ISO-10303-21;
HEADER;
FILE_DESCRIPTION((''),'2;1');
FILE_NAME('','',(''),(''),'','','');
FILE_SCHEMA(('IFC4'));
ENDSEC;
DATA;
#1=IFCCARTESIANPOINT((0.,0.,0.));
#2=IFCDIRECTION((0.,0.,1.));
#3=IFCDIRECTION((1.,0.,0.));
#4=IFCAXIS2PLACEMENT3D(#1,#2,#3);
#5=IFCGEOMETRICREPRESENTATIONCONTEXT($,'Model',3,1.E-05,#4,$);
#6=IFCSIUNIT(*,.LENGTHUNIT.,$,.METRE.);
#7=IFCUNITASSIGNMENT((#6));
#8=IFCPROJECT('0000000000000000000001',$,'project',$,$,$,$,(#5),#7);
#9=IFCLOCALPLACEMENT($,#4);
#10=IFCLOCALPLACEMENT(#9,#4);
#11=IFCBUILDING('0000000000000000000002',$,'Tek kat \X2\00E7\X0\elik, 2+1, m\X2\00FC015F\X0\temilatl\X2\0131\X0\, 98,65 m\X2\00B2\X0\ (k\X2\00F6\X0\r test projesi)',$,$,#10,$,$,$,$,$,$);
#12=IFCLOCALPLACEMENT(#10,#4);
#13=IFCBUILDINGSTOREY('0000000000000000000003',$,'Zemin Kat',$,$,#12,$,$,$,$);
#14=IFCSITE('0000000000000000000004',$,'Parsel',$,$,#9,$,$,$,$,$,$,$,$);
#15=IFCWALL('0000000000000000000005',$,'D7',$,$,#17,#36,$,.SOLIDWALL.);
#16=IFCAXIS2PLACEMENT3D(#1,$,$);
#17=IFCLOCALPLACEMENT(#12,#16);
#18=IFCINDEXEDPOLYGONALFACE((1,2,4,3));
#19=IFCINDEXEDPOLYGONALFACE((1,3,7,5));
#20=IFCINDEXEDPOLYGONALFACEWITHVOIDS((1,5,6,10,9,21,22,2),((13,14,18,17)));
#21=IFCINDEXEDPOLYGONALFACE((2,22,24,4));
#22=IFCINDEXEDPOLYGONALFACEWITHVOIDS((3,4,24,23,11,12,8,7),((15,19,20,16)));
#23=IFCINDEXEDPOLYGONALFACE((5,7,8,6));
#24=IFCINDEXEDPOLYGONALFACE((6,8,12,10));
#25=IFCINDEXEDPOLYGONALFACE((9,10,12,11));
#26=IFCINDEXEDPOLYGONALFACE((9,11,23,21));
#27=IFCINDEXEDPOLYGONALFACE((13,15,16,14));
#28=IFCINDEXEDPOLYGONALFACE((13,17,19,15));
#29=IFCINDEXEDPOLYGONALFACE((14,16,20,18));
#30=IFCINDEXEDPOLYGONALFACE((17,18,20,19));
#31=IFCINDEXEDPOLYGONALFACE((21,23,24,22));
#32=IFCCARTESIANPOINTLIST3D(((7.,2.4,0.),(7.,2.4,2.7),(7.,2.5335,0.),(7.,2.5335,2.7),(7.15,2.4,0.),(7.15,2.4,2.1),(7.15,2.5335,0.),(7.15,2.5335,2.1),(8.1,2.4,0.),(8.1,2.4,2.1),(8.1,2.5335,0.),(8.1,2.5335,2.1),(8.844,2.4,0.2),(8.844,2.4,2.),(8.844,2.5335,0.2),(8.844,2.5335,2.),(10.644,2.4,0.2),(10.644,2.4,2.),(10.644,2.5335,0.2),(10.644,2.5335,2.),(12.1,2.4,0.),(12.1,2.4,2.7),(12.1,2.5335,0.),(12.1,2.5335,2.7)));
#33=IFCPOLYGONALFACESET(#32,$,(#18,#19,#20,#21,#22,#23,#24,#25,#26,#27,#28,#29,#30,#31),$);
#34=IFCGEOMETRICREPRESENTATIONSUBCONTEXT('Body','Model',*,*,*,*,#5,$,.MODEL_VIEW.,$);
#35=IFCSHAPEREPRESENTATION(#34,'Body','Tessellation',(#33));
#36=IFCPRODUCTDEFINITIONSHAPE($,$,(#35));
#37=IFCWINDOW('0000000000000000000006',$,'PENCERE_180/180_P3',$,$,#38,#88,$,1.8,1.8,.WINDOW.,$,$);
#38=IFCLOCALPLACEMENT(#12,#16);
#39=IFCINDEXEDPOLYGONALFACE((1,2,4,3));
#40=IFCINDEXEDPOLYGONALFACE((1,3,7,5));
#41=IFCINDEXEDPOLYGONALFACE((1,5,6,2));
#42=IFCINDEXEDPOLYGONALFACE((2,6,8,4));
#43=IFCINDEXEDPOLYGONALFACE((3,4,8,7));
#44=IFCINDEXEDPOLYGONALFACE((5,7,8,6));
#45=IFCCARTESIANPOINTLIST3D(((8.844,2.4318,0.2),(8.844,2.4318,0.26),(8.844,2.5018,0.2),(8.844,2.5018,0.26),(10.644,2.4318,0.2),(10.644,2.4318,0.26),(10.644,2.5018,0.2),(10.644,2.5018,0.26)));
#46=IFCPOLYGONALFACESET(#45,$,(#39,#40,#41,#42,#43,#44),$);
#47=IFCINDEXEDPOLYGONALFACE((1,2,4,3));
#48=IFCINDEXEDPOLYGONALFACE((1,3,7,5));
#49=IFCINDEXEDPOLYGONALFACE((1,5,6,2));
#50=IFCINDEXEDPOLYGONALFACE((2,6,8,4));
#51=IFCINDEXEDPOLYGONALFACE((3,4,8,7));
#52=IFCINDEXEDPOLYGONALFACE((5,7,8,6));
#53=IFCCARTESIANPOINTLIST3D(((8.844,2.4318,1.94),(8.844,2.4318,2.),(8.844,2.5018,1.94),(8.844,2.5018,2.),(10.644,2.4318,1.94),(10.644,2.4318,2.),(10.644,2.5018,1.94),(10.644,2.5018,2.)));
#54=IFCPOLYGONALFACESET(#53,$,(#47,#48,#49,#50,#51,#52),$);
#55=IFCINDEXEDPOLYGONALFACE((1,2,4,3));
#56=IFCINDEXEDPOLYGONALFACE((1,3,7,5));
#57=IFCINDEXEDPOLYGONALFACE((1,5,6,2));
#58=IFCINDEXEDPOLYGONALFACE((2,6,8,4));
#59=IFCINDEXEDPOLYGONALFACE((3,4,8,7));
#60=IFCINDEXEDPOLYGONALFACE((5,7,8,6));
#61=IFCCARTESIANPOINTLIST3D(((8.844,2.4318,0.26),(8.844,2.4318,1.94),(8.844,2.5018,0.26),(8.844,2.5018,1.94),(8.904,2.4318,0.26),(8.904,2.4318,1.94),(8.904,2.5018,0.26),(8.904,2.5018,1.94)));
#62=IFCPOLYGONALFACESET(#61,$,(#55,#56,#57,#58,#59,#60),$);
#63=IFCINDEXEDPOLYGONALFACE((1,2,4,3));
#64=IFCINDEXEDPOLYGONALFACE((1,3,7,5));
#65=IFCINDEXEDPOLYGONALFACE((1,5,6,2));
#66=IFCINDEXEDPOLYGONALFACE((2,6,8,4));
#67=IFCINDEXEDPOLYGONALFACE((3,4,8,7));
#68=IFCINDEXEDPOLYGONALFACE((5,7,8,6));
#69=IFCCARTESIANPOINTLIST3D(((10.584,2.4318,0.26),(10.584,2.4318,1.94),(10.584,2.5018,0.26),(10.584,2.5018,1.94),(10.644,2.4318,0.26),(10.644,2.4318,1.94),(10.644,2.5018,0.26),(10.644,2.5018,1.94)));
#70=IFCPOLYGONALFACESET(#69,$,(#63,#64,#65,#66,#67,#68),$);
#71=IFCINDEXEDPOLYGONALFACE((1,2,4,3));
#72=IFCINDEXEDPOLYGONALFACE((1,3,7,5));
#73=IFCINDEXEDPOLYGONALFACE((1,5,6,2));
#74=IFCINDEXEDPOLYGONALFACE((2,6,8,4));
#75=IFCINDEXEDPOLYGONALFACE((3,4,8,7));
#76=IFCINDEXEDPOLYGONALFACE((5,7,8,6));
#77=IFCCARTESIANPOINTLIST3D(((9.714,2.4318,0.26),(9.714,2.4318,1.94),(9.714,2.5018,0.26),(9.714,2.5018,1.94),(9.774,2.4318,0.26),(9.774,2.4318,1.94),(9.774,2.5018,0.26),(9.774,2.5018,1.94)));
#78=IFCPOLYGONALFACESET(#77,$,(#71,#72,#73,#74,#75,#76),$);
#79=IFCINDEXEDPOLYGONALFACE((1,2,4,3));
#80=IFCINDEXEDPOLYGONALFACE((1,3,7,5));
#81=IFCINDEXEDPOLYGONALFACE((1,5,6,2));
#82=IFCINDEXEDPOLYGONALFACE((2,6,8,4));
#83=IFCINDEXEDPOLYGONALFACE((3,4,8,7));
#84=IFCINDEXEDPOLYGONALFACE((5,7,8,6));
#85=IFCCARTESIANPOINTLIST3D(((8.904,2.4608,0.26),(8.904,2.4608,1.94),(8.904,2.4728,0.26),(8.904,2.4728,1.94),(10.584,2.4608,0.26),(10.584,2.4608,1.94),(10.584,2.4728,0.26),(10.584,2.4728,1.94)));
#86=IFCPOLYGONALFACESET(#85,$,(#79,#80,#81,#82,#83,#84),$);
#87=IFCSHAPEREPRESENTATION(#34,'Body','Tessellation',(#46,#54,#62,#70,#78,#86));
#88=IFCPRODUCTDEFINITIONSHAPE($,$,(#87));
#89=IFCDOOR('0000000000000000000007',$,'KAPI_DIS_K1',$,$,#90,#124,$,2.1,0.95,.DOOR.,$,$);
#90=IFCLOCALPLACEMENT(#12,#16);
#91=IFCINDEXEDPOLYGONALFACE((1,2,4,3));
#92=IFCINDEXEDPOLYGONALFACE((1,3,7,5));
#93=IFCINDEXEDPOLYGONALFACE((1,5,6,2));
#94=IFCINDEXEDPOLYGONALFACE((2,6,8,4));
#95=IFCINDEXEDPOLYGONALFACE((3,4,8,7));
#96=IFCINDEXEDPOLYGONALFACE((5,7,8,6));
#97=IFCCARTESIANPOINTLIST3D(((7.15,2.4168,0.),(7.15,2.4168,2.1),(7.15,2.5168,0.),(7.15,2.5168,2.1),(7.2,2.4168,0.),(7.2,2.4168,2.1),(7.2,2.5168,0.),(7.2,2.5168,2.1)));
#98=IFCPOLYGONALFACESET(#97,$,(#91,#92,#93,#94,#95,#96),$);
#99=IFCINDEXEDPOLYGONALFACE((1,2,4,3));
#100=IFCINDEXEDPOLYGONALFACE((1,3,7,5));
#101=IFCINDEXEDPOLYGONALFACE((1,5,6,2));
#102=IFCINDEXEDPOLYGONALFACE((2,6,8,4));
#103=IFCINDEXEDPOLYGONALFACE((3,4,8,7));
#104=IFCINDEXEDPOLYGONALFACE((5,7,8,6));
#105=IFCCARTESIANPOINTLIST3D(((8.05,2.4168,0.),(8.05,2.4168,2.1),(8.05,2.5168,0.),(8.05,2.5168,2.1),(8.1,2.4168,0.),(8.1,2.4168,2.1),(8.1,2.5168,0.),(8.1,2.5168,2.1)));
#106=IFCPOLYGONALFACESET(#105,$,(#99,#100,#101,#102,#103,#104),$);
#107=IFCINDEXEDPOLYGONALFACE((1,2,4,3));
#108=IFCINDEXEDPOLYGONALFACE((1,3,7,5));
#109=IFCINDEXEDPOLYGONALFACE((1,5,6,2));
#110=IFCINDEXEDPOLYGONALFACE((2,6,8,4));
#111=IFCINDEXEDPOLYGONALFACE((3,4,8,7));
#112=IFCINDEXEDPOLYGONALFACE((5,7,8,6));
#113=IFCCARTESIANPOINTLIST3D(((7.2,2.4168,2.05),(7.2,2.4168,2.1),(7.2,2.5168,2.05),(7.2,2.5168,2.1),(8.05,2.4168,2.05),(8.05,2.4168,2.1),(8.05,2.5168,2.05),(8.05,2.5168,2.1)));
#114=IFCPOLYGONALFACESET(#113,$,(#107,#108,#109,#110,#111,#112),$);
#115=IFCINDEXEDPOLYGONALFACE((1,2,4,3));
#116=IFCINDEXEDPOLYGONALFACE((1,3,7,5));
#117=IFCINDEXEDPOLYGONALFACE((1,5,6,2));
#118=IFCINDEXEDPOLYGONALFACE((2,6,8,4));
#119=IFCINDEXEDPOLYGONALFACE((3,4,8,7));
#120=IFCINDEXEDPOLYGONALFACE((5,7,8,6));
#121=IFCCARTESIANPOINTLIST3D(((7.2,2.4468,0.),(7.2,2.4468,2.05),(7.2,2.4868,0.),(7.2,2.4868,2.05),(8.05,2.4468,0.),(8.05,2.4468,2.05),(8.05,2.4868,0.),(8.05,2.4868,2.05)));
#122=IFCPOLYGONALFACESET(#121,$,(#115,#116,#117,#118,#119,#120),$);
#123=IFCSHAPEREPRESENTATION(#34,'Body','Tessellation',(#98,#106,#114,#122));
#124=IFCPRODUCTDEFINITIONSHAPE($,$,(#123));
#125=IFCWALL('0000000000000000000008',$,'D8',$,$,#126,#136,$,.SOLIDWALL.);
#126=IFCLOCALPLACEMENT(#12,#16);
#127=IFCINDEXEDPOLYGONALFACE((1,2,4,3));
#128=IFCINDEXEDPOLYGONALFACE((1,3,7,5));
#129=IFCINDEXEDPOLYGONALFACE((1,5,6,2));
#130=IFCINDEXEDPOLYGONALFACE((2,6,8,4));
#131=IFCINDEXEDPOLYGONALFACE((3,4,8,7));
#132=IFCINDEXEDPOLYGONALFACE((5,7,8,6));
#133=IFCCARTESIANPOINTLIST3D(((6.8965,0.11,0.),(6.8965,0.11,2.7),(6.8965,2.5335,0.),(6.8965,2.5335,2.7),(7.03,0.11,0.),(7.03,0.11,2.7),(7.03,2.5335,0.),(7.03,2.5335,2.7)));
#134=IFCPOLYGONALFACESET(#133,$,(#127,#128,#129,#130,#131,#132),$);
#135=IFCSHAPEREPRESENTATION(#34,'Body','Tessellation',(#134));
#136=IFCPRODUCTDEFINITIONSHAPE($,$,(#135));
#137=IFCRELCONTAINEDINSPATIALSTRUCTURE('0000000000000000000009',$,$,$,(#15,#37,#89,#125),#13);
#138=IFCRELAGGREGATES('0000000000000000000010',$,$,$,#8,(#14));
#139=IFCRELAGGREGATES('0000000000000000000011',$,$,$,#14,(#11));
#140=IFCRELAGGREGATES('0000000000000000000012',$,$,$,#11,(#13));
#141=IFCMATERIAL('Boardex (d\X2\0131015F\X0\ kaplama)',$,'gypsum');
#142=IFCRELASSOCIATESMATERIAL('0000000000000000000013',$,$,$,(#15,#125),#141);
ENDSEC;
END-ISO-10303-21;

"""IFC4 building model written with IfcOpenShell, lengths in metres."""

from ifc_helpers import new_model, si_unit, frame, origin_with_axes, place, context, subcontext, project, spatial, line, indexed_curve, outline, extrude, material, element, fill, save


model = new_model("IFC4")

# Units and contexts
model_context = context("Model", 3, precision=1e-05, world=origin_with_axes())
body_context = subcontext(model_context, "Body", "Model", "MODEL_VIEW")
ifc_project = project(units=[si_unit("LENGTHUNIT", "METRE")], contexts=[model_context])

# Site, building, storey
site_placement = place(None, origin_with_axes())
site = spatial("IfcSite", under=ifc_project, at=site_placement, Name="Parsel")
building_placement = place(site_placement, origin_with_axes())
building = spatial("IfcBuilding", under=site, at=building_placement, Name="Tek kat çelik, 2+1, müştemilatlı, 98,65 m² (kör test projesi)")
storey_placement = place(building_placement, origin_with_axes())
storey = spatial("IfcBuildingStorey", under=building, at=storey_placement, Name="Zemin Kat")

# Shared definitions
ifc_material_1 = material(Name="Boardex (dış kaplama)", Category="gypsum")

# Wall, openings, window, door
wall_1_placement = place(storey_placement, origin_with_axes())
wall_1 = element("IfcWall", 1, at=wall_1_placement, inside=storey, material=ifc_material_1, Name="D7", PredefinedType="SOLIDWALL", context=body_context, shape_type="SweptSolid", body=[
    extrude(outline(indexed_curve([(0.0, 0.0), (5.1, 0.0), (5.1, 0.1335), (0.0, 0.1335)], segments=[line(1, 2, 3, 4, 1)])), frame((7.0, 2.4, 0.0), z_axis=(0.0, 0.0, 1.0), x_axis=(1.0, 0.0, 0.0)), (0.0, 0.0, 1.0), 2.7),
])
opening_1_placement = place(wall_1_placement, origin_with_axes())
opening_1 = element("IfcOpeningElement", 2, at=opening_1_placement, cuts=wall_1, PredefinedType="OPENING", context=body_context, shape_type="SweptSolid", body=[
    extrude(outline(indexed_curve([(0.0, 0.0), (1.8, 0.0), (1.8, 0.1735), (0.0, 0.1735)], segments=[line(1, 2, 3, 4, 1)])), frame((8.844, 2.38, 0.2), z_axis=(0.0, 0.0, 1.0), x_axis=(1.0, 0.0, 0.0)), (0.0, 0.0, 1.0), 1.8),
])
opening_2_placement = place(wall_1_placement, origin_with_axes())
opening_2 = element("IfcOpeningElement", 3, at=opening_2_placement, cuts=wall_1, PredefinedType="OPENING", context=body_context, shape_type="SweptSolid", body=[
    extrude(outline(indexed_curve([(0.0, 0.0), (0.95, 0.0), (0.95, 0.1735), (0.0, 0.1735)], segments=[line(1, 2, 3, 4, 1)])), frame((7.15, 2.38, 0.0), z_axis=(0.0, 0.0, 1.0), x_axis=(1.0, 0.0, 0.0)), (0.0, 0.0, 1.0), 2.1),
])
window_1_placement = place(storey_placement, origin_with_axes())
window_1 = element("IfcWindow", 4, at=window_1_placement, inside=storey, Name="PENCERE_180/180_P3", OverallHeight=1.8, OverallWidth=1.8, PredefinedType="WINDOW", context=body_context, shape_type="SweptSolid", body=[
    extrude(outline(indexed_curve([(0.0, 0.0), (1.8, 0.0), (1.8, 0.07), (0.0, 0.07)], segments=[line(1, 2, 3, 4, 1)])), frame((8.844, 2.4318, 0.2), z_axis=(0.0, 0.0, 1.0), x_axis=(1.0, 0.0, 0.0)), (0.0, 0.0, 1.0), 0.06),
    extrude(outline(indexed_curve([(0.0, 0.0), (1.8, 0.0), (1.8, 0.07), (0.0, 0.07)], segments=[line(1, 2, 3, 4, 1)])), frame((8.844, 2.4318, 1.94), z_axis=(0.0, 0.0, 1.0), x_axis=(1.0, 0.0, 0.0)), (0.0, 0.0, 1.0), 0.06),
    extrude(outline(indexed_curve([(0.0, 0.0), (0.06, 0.0), (0.06, 0.07), (0.0, 0.07)], segments=[line(1, 2, 3, 4, 1)])), frame((8.844, 2.4318, 0.26), z_axis=(0.0, 0.0, 1.0), x_axis=(1.0, 0.0, 0.0)), (0.0, 0.0, 1.0), 1.68),
    extrude(outline(indexed_curve([(0.0, 0.0), (0.06, 0.0), (0.06, 0.07), (0.0, 0.07)], segments=[line(1, 2, 3, 4, 1)])), frame((10.584, 2.4318, 0.26), z_axis=(0.0, 0.0, 1.0), x_axis=(1.0, 0.0, 0.0)), (0.0, 0.0, 1.0), 1.68),
    extrude(outline(indexed_curve([(0.0, 0.0), (0.06, 0.0), (0.06, 0.07), (0.0, 0.07)], segments=[line(1, 2, 3, 4, 1)])), frame((9.714, 2.4318, 0.26), z_axis=(0.0, 0.0, 1.0), x_axis=(1.0, 0.0, 0.0)), (0.0, 0.0, 1.0), 1.68),
    extrude(outline(indexed_curve([(0.0, 0.0), (1.68, 0.0), (1.68, 0.012), (0.0, 0.012)], segments=[line(1, 2, 3, 4, 1)])), frame((8.904, 2.4608, 0.26), z_axis=(0.0, 0.0, 1.0), x_axis=(1.0, 0.0, 0.0)), (0.0, 0.0, 1.0), 1.68),
])
fill(opening_1, window_1)
door_1_placement = place(storey_placement, origin_with_axes())
door_1 = element("IfcDoor", 5, at=door_1_placement, inside=storey, Name="KAPI_DIS_K1", OverallHeight=2.1, OverallWidth=0.95, PredefinedType="DOOR", context=body_context, shape_type="SweptSolid", body=[
    extrude(outline(indexed_curve([(0.0, 0.0), (0.05, 0.0), (0.05, 0.1), (0.0, 0.1)], segments=[line(1, 2, 3, 4, 1)])), frame((7.15, 2.4167, 0.0), z_axis=(0.0, 0.0, 1.0), x_axis=(1.0, 0.0, 0.0)), (0.0, 0.0, 1.0), 2.1),
    extrude(outline(indexed_curve([(0.0, 0.0), (0.05, 0.0), (0.05, 0.1), (0.0, 0.1)], segments=[line(1, 2, 3, 4, 1)])), frame((8.05, 2.4167, 0.0), z_axis=(0.0, 0.0, 1.0), x_axis=(1.0, 0.0, 0.0)), (0.0, 0.0, 1.0), 2.1),
    extrude(outline(indexed_curve([(0.0, 0.0), (0.85, 0.0), (0.85, 0.1), (0.0, 0.1)], segments=[line(1, 2, 3, 4, 1)])), frame((7.2, 2.4167, 2.05), z_axis=(0.0, 0.0, 1.0), x_axis=(1.0, 0.0, 0.0)), (0.0, 0.0, 1.0), 0.05),
    extrude(outline(indexed_curve([(0.0, 0.0), (0.85, 0.0), (0.85, 0.04), (0.0, 0.04)], segments=[line(1, 2, 3, 4, 1)])), frame((7.2, 2.4468, 0.0), z_axis=(0.0, 0.0, 1.0), x_axis=(1.0, 0.0, 0.0)), (0.0, 0.0, 1.0), 2.05),
])
fill(opening_2, door_1)

# Wall
wall_2_placement = place(storey_placement, origin_with_axes())
element("IfcWall", 6, at=wall_2_placement, inside=storey, material=ifc_material_1, Name="D8", PredefinedType="SOLIDWALL", context=body_context, shape_type="SweptSolid", body=[
    extrude(outline(indexed_curve([(0.0, 0.0), (0.1335, 0.0), (0.1335, 2.4235), (0.0, 2.4235)], segments=[line(1, 2, 3, 4, 1)])), frame((6.8965, 0.11, 0.0), z_axis=(0.0, 0.0, 1.0), x_axis=(1.0, 0.0, 0.0)), (0.0, 0.0, 1.0), 2.7),
])

save(model, "model.ifc")
